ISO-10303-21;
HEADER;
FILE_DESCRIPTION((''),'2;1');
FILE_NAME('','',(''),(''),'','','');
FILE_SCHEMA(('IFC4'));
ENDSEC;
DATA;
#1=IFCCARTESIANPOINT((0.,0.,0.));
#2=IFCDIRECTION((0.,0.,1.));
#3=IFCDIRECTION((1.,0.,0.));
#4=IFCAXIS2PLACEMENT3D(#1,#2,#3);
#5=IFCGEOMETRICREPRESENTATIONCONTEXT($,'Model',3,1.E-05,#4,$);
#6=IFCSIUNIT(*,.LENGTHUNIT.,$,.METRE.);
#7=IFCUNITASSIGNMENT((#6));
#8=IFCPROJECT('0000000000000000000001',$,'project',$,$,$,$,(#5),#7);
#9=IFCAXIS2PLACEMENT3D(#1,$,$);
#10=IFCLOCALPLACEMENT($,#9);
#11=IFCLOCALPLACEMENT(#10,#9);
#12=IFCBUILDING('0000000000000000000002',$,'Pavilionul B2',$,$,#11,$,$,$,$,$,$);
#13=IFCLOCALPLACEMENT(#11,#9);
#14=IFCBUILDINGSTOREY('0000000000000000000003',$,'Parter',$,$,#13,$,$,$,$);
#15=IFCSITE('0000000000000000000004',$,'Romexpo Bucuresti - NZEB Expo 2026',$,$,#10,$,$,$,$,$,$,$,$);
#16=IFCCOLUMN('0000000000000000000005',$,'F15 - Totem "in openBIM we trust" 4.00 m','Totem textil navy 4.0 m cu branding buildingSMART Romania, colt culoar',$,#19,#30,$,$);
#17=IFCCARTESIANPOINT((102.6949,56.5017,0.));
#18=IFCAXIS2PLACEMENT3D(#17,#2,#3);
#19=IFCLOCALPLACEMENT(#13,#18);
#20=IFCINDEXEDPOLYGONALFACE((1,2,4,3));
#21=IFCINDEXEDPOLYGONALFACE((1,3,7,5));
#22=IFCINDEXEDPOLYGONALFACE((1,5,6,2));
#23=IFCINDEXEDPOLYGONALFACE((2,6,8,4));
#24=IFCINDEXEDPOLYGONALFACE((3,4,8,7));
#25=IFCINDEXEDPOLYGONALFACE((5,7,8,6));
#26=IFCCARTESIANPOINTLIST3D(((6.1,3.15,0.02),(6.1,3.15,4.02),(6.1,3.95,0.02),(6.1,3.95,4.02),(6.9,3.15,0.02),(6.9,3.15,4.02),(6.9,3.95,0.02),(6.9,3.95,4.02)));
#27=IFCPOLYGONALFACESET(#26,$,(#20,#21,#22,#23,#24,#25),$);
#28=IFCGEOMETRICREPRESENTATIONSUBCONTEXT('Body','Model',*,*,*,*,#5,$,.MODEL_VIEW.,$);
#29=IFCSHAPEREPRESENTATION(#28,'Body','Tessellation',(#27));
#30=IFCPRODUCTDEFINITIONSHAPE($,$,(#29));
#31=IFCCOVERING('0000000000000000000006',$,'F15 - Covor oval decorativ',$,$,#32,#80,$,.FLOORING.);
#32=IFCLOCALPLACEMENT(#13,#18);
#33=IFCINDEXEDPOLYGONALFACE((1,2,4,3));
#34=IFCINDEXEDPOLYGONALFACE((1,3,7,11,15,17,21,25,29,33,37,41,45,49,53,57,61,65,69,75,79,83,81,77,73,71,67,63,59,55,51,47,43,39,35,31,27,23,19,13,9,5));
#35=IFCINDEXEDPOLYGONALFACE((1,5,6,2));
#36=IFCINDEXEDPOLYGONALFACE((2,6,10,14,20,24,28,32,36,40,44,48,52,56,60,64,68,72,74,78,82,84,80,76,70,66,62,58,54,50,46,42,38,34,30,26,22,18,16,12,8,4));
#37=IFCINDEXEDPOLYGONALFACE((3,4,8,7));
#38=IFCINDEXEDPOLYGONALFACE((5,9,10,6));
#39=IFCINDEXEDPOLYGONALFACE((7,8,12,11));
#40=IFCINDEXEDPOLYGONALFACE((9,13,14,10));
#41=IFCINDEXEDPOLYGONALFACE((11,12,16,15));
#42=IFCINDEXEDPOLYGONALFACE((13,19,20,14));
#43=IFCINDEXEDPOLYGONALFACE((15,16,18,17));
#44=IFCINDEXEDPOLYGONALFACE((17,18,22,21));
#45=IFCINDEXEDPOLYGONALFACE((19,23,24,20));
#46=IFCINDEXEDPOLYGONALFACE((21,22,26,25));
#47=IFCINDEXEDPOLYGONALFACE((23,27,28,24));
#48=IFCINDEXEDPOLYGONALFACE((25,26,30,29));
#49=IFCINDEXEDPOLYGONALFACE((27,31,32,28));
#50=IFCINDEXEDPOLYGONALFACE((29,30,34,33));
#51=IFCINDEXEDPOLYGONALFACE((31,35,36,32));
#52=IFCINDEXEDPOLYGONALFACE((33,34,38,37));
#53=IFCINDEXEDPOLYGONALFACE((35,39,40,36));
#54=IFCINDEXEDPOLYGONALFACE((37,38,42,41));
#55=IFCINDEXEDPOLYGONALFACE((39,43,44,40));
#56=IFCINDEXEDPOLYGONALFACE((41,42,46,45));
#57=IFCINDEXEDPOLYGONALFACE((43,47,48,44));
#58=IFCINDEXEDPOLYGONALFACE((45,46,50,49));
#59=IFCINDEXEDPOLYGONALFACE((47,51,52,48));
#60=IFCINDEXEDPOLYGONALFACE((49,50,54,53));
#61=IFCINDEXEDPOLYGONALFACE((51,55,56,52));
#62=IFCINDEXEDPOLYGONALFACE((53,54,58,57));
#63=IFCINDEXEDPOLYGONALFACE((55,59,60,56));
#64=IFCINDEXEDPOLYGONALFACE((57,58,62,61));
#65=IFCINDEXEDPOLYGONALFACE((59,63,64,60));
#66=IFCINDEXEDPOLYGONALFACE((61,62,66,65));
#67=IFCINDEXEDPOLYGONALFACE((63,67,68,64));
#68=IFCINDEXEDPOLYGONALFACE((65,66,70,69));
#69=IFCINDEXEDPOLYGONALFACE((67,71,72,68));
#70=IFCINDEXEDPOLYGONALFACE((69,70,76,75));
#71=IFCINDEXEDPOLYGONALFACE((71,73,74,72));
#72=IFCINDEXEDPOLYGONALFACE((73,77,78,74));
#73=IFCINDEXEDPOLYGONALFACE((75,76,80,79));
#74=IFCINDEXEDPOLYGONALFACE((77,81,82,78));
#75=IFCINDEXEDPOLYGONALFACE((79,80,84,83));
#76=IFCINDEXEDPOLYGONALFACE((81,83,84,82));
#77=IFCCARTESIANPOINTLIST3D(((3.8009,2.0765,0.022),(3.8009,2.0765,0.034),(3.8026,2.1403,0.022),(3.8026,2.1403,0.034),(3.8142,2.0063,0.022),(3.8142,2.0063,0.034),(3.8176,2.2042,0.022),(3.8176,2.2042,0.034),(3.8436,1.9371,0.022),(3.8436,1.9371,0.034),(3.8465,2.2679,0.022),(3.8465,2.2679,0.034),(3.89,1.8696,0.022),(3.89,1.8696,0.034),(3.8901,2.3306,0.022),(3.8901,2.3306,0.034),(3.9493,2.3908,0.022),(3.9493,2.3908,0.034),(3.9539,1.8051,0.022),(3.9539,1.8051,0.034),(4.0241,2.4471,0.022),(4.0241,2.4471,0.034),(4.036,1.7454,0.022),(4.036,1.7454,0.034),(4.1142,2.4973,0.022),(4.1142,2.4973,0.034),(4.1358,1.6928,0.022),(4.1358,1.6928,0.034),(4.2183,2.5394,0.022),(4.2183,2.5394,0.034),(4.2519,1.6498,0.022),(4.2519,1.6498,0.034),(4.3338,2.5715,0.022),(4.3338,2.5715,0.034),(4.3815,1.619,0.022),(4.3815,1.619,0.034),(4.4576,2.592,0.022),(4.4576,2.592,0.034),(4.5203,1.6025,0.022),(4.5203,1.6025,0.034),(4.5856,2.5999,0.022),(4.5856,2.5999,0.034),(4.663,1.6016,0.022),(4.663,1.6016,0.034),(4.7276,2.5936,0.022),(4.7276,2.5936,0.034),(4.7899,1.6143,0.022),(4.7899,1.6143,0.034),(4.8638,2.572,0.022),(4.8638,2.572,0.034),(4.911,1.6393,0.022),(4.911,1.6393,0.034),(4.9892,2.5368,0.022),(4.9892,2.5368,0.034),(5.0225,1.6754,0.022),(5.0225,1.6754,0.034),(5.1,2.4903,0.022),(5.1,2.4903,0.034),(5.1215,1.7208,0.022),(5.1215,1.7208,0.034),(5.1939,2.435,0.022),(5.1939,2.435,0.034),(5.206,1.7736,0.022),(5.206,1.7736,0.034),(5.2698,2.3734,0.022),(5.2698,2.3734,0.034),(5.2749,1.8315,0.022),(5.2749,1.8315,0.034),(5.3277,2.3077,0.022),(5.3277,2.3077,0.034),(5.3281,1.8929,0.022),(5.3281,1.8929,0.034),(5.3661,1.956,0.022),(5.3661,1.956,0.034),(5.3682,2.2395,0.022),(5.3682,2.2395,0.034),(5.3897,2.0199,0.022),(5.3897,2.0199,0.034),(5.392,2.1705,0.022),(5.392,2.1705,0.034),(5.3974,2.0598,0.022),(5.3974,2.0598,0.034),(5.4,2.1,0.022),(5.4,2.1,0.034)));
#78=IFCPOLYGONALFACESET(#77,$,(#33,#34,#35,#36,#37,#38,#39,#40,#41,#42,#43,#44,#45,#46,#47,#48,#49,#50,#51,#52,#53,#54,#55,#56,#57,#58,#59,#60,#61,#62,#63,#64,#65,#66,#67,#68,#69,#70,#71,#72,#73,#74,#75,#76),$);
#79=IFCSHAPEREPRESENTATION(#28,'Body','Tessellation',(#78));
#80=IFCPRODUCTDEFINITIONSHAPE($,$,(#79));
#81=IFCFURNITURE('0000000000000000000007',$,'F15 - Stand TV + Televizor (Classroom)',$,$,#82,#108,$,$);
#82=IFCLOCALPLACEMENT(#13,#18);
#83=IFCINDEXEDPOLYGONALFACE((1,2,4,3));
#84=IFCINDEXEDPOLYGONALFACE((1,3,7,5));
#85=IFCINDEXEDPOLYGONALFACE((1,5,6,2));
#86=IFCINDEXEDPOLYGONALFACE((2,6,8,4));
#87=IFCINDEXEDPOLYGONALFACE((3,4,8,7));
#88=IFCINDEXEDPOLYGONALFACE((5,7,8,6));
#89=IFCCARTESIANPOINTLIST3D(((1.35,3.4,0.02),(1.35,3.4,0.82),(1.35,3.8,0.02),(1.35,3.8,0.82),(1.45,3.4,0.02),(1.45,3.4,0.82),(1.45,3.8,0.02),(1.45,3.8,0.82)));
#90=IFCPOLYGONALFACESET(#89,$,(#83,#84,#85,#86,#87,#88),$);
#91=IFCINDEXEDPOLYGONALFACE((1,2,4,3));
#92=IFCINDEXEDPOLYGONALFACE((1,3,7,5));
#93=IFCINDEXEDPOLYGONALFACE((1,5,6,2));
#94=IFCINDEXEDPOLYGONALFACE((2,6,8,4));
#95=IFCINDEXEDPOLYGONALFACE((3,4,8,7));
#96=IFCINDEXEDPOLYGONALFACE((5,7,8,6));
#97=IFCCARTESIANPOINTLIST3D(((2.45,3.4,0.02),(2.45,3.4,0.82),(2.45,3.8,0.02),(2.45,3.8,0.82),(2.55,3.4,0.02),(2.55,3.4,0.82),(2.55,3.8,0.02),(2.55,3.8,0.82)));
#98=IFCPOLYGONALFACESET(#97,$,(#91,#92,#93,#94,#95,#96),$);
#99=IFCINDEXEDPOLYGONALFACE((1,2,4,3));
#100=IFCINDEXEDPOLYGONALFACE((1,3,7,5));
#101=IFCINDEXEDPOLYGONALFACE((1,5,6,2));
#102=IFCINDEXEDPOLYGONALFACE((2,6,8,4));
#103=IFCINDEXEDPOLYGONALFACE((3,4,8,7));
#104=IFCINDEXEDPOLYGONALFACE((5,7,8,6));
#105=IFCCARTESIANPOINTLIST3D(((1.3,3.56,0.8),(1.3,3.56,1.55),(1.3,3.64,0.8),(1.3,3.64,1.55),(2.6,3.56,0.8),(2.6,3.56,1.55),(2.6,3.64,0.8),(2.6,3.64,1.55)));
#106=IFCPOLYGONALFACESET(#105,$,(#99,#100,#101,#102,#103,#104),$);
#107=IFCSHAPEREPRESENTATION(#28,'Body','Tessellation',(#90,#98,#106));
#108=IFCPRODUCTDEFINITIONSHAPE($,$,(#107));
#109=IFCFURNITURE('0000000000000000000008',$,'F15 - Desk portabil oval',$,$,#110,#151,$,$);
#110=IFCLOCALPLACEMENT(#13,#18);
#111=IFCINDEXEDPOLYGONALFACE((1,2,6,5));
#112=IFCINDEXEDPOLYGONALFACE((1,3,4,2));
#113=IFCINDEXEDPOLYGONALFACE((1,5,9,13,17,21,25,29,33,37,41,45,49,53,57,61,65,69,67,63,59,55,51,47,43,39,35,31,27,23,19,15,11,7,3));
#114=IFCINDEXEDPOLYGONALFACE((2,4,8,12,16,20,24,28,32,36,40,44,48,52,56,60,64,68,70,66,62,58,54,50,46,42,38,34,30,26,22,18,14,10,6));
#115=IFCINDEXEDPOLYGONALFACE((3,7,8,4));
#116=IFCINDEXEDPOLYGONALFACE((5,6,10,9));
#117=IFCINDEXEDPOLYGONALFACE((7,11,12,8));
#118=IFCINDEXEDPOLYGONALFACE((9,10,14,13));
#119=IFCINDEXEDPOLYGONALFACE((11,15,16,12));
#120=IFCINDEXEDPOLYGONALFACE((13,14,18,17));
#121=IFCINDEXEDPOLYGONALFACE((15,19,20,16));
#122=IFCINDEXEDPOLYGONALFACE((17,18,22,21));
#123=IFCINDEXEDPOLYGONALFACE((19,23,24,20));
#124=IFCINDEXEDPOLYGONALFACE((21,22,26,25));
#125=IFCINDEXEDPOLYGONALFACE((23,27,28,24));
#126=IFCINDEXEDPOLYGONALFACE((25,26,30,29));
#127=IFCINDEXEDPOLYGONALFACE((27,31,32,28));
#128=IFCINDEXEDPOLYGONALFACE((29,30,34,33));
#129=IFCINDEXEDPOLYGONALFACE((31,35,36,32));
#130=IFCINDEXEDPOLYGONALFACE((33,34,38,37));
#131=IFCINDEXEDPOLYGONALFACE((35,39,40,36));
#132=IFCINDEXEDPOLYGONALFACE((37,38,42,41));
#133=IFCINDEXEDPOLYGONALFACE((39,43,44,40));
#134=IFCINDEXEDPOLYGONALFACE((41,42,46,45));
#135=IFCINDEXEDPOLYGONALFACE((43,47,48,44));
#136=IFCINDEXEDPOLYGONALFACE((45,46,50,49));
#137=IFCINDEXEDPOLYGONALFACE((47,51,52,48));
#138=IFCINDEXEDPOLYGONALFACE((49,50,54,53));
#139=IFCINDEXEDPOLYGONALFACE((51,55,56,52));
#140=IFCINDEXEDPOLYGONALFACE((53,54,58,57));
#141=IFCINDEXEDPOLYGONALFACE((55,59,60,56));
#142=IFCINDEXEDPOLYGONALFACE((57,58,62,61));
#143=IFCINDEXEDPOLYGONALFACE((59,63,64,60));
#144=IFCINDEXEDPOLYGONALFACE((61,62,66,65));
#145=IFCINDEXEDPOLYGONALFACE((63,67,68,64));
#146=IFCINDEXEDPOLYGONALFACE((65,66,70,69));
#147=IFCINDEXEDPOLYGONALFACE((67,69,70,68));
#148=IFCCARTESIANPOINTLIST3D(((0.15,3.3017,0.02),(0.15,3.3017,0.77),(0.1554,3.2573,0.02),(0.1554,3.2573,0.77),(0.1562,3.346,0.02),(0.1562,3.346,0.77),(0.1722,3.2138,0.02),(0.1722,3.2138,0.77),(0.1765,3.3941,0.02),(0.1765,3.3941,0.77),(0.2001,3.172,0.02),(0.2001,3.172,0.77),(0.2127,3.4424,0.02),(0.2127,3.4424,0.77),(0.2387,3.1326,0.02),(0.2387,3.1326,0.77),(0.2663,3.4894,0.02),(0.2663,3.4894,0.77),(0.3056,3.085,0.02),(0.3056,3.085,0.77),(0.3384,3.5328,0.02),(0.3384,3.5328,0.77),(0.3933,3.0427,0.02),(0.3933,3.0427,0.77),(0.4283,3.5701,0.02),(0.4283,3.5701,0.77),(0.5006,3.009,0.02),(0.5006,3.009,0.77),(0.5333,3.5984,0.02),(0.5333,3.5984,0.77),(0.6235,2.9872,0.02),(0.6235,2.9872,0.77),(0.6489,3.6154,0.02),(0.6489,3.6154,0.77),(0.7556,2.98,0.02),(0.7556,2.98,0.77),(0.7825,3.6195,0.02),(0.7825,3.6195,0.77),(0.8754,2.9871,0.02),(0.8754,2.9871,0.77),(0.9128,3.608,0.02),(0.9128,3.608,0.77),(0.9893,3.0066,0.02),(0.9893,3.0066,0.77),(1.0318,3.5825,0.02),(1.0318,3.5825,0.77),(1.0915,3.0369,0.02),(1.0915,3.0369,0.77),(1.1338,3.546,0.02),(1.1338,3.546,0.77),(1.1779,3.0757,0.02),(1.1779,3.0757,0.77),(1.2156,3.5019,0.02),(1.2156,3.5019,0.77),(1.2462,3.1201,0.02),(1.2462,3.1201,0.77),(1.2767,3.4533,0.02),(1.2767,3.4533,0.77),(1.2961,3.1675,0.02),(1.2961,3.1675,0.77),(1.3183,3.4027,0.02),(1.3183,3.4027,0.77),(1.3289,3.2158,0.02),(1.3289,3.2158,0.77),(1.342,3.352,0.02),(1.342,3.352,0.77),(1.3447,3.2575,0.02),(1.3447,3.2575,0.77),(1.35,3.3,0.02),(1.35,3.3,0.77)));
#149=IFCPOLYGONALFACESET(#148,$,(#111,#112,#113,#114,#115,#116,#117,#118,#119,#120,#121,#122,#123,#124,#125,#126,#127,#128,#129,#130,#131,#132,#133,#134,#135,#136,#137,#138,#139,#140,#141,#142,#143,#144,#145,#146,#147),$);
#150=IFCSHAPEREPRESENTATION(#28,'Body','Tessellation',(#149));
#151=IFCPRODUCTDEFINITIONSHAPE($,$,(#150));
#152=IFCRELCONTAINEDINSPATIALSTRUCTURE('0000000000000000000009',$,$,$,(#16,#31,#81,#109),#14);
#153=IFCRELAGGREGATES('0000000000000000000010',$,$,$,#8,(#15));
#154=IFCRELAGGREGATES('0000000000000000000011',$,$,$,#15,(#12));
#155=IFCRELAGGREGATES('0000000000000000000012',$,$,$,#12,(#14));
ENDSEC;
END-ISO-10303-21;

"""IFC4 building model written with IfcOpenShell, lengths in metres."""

from ifc_helpers import new_model, si_unit, frame, frame_2d, origin, origin_with_axes, place, context, subcontext, project, spatial, rectangle, ellipse, extrude, element, save


model = new_model("IFC4")

# Units and contexts
model_context = context("Model", 3, precision=1e-05, world=origin_with_axes())
body_context = subcontext(model_context, "Body", "Model", "MODEL_VIEW")
ifc_project = project(units=[si_unit("LENGTHUNIT", "METRE")], contexts=[model_context])

# Site, building, storey
site_placement = place(None, origin())
site = spatial("IfcSite", under=ifc_project, at=site_placement, Name="Romexpo Bucuresti - NZEB Expo 2026")
building_placement = place(site_placement, origin())
building = spatial("IfcBuilding", under=site, at=building_placement, Name="Pavilionul B2")
storey_placement = place(building_placement, origin())
storey = spatial("IfcBuildingStorey", under=building, at=storey_placement, Name="Parter")

# Column
column_placement = place(storey_placement, frame((102.6949, 56.5017, 0.0), z_axis=(0.0, 0.0, 1.0), x_axis=(1.0, 0.0, 0.0)))
element("IfcColumn", 1, at=column_placement, inside=storey, Name="F15 - Totem \"in openBIM we trust\" 4.00 m", Description="Totem textil navy 4.0 m cu branding buildingSMART Romania, colt culoar", context=body_context, shape_type="SweptSolid", body=[
    extrude(rectangle(XDim=0.8, YDim=0.8, at=frame_2d((6.5, 3.55))), frame((0.0, 0.0, 0.02)), (0.0, 0.0, 1.0), 4.0),
])

# Covering
covering_placement = place(storey_placement, frame((102.6949, 56.5017, 0.0), z_axis=(0.0, 0.0, 1.0), x_axis=(1.0, 0.0, 0.0)))
element("IfcCovering", 2, at=covering_placement, inside=storey, Name="F15 - Covor oval decorativ", PredefinedType="FLOORING", context=body_context, shape_type="SweptSolid", body=[
    extrude(ellipse(SemiAxis1=0.8, SemiAxis2=0.5, at=frame_2d((4.6, 2.1))), frame((0.0, 0.0, 0.022)), (0.0, 0.0, 1.0), 0.012),
])

# Furniture
furniture_1_placement = place(storey_placement, frame((102.6949, 56.5017, 0.0), z_axis=(0.0, 0.0, 1.0), x_axis=(1.0, 0.0, 0.0)))
element("IfcFurniture", 3, at=furniture_1_placement, inside=storey, Name="F15 - Stand TV + Televizor (Classroom)", context=body_context, shape_type="SweptSolid", body=[
    extrude(rectangle(XDim=0.1, YDim=0.4, at=frame_2d((1.4, 3.6))), frame((0.0, 0.0, 0.02)), (0.0, 0.0, 1.0), 0.8),
    extrude(rectangle(XDim=0.1, YDim=0.4, at=frame_2d((2.5, 3.6))), frame((0.0, 0.0, 0.02)), (0.0, 0.0, 1.0), 0.8),
    extrude(rectangle(XDim=1.3, YDim=0.08, at=frame_2d((1.95, 3.6))), frame((0.0, 0.0, 0.8)), (0.0, 0.0, 1.0), 0.75),
])
furniture_2_placement = place(storey_placement, frame((102.6949, 56.5017, 0.0), z_axis=(0.0, 0.0, 1.0), x_axis=(1.0, 0.0, 0.0)))
element("IfcFurniture", 4, at=furniture_2_placement, inside=storey, Name="F15 - Desk portabil oval", context=body_context, shape_type="SweptSolid", body=[
    extrude(ellipse(SemiAxis1=0.6, SemiAxis2=0.32, at=frame_2d((0.75, 3.3))), frame((0.0, 0.0, 0.02)), (0.0, 0.0, 1.0), 0.75),
])

save(model, "model.ifc")
